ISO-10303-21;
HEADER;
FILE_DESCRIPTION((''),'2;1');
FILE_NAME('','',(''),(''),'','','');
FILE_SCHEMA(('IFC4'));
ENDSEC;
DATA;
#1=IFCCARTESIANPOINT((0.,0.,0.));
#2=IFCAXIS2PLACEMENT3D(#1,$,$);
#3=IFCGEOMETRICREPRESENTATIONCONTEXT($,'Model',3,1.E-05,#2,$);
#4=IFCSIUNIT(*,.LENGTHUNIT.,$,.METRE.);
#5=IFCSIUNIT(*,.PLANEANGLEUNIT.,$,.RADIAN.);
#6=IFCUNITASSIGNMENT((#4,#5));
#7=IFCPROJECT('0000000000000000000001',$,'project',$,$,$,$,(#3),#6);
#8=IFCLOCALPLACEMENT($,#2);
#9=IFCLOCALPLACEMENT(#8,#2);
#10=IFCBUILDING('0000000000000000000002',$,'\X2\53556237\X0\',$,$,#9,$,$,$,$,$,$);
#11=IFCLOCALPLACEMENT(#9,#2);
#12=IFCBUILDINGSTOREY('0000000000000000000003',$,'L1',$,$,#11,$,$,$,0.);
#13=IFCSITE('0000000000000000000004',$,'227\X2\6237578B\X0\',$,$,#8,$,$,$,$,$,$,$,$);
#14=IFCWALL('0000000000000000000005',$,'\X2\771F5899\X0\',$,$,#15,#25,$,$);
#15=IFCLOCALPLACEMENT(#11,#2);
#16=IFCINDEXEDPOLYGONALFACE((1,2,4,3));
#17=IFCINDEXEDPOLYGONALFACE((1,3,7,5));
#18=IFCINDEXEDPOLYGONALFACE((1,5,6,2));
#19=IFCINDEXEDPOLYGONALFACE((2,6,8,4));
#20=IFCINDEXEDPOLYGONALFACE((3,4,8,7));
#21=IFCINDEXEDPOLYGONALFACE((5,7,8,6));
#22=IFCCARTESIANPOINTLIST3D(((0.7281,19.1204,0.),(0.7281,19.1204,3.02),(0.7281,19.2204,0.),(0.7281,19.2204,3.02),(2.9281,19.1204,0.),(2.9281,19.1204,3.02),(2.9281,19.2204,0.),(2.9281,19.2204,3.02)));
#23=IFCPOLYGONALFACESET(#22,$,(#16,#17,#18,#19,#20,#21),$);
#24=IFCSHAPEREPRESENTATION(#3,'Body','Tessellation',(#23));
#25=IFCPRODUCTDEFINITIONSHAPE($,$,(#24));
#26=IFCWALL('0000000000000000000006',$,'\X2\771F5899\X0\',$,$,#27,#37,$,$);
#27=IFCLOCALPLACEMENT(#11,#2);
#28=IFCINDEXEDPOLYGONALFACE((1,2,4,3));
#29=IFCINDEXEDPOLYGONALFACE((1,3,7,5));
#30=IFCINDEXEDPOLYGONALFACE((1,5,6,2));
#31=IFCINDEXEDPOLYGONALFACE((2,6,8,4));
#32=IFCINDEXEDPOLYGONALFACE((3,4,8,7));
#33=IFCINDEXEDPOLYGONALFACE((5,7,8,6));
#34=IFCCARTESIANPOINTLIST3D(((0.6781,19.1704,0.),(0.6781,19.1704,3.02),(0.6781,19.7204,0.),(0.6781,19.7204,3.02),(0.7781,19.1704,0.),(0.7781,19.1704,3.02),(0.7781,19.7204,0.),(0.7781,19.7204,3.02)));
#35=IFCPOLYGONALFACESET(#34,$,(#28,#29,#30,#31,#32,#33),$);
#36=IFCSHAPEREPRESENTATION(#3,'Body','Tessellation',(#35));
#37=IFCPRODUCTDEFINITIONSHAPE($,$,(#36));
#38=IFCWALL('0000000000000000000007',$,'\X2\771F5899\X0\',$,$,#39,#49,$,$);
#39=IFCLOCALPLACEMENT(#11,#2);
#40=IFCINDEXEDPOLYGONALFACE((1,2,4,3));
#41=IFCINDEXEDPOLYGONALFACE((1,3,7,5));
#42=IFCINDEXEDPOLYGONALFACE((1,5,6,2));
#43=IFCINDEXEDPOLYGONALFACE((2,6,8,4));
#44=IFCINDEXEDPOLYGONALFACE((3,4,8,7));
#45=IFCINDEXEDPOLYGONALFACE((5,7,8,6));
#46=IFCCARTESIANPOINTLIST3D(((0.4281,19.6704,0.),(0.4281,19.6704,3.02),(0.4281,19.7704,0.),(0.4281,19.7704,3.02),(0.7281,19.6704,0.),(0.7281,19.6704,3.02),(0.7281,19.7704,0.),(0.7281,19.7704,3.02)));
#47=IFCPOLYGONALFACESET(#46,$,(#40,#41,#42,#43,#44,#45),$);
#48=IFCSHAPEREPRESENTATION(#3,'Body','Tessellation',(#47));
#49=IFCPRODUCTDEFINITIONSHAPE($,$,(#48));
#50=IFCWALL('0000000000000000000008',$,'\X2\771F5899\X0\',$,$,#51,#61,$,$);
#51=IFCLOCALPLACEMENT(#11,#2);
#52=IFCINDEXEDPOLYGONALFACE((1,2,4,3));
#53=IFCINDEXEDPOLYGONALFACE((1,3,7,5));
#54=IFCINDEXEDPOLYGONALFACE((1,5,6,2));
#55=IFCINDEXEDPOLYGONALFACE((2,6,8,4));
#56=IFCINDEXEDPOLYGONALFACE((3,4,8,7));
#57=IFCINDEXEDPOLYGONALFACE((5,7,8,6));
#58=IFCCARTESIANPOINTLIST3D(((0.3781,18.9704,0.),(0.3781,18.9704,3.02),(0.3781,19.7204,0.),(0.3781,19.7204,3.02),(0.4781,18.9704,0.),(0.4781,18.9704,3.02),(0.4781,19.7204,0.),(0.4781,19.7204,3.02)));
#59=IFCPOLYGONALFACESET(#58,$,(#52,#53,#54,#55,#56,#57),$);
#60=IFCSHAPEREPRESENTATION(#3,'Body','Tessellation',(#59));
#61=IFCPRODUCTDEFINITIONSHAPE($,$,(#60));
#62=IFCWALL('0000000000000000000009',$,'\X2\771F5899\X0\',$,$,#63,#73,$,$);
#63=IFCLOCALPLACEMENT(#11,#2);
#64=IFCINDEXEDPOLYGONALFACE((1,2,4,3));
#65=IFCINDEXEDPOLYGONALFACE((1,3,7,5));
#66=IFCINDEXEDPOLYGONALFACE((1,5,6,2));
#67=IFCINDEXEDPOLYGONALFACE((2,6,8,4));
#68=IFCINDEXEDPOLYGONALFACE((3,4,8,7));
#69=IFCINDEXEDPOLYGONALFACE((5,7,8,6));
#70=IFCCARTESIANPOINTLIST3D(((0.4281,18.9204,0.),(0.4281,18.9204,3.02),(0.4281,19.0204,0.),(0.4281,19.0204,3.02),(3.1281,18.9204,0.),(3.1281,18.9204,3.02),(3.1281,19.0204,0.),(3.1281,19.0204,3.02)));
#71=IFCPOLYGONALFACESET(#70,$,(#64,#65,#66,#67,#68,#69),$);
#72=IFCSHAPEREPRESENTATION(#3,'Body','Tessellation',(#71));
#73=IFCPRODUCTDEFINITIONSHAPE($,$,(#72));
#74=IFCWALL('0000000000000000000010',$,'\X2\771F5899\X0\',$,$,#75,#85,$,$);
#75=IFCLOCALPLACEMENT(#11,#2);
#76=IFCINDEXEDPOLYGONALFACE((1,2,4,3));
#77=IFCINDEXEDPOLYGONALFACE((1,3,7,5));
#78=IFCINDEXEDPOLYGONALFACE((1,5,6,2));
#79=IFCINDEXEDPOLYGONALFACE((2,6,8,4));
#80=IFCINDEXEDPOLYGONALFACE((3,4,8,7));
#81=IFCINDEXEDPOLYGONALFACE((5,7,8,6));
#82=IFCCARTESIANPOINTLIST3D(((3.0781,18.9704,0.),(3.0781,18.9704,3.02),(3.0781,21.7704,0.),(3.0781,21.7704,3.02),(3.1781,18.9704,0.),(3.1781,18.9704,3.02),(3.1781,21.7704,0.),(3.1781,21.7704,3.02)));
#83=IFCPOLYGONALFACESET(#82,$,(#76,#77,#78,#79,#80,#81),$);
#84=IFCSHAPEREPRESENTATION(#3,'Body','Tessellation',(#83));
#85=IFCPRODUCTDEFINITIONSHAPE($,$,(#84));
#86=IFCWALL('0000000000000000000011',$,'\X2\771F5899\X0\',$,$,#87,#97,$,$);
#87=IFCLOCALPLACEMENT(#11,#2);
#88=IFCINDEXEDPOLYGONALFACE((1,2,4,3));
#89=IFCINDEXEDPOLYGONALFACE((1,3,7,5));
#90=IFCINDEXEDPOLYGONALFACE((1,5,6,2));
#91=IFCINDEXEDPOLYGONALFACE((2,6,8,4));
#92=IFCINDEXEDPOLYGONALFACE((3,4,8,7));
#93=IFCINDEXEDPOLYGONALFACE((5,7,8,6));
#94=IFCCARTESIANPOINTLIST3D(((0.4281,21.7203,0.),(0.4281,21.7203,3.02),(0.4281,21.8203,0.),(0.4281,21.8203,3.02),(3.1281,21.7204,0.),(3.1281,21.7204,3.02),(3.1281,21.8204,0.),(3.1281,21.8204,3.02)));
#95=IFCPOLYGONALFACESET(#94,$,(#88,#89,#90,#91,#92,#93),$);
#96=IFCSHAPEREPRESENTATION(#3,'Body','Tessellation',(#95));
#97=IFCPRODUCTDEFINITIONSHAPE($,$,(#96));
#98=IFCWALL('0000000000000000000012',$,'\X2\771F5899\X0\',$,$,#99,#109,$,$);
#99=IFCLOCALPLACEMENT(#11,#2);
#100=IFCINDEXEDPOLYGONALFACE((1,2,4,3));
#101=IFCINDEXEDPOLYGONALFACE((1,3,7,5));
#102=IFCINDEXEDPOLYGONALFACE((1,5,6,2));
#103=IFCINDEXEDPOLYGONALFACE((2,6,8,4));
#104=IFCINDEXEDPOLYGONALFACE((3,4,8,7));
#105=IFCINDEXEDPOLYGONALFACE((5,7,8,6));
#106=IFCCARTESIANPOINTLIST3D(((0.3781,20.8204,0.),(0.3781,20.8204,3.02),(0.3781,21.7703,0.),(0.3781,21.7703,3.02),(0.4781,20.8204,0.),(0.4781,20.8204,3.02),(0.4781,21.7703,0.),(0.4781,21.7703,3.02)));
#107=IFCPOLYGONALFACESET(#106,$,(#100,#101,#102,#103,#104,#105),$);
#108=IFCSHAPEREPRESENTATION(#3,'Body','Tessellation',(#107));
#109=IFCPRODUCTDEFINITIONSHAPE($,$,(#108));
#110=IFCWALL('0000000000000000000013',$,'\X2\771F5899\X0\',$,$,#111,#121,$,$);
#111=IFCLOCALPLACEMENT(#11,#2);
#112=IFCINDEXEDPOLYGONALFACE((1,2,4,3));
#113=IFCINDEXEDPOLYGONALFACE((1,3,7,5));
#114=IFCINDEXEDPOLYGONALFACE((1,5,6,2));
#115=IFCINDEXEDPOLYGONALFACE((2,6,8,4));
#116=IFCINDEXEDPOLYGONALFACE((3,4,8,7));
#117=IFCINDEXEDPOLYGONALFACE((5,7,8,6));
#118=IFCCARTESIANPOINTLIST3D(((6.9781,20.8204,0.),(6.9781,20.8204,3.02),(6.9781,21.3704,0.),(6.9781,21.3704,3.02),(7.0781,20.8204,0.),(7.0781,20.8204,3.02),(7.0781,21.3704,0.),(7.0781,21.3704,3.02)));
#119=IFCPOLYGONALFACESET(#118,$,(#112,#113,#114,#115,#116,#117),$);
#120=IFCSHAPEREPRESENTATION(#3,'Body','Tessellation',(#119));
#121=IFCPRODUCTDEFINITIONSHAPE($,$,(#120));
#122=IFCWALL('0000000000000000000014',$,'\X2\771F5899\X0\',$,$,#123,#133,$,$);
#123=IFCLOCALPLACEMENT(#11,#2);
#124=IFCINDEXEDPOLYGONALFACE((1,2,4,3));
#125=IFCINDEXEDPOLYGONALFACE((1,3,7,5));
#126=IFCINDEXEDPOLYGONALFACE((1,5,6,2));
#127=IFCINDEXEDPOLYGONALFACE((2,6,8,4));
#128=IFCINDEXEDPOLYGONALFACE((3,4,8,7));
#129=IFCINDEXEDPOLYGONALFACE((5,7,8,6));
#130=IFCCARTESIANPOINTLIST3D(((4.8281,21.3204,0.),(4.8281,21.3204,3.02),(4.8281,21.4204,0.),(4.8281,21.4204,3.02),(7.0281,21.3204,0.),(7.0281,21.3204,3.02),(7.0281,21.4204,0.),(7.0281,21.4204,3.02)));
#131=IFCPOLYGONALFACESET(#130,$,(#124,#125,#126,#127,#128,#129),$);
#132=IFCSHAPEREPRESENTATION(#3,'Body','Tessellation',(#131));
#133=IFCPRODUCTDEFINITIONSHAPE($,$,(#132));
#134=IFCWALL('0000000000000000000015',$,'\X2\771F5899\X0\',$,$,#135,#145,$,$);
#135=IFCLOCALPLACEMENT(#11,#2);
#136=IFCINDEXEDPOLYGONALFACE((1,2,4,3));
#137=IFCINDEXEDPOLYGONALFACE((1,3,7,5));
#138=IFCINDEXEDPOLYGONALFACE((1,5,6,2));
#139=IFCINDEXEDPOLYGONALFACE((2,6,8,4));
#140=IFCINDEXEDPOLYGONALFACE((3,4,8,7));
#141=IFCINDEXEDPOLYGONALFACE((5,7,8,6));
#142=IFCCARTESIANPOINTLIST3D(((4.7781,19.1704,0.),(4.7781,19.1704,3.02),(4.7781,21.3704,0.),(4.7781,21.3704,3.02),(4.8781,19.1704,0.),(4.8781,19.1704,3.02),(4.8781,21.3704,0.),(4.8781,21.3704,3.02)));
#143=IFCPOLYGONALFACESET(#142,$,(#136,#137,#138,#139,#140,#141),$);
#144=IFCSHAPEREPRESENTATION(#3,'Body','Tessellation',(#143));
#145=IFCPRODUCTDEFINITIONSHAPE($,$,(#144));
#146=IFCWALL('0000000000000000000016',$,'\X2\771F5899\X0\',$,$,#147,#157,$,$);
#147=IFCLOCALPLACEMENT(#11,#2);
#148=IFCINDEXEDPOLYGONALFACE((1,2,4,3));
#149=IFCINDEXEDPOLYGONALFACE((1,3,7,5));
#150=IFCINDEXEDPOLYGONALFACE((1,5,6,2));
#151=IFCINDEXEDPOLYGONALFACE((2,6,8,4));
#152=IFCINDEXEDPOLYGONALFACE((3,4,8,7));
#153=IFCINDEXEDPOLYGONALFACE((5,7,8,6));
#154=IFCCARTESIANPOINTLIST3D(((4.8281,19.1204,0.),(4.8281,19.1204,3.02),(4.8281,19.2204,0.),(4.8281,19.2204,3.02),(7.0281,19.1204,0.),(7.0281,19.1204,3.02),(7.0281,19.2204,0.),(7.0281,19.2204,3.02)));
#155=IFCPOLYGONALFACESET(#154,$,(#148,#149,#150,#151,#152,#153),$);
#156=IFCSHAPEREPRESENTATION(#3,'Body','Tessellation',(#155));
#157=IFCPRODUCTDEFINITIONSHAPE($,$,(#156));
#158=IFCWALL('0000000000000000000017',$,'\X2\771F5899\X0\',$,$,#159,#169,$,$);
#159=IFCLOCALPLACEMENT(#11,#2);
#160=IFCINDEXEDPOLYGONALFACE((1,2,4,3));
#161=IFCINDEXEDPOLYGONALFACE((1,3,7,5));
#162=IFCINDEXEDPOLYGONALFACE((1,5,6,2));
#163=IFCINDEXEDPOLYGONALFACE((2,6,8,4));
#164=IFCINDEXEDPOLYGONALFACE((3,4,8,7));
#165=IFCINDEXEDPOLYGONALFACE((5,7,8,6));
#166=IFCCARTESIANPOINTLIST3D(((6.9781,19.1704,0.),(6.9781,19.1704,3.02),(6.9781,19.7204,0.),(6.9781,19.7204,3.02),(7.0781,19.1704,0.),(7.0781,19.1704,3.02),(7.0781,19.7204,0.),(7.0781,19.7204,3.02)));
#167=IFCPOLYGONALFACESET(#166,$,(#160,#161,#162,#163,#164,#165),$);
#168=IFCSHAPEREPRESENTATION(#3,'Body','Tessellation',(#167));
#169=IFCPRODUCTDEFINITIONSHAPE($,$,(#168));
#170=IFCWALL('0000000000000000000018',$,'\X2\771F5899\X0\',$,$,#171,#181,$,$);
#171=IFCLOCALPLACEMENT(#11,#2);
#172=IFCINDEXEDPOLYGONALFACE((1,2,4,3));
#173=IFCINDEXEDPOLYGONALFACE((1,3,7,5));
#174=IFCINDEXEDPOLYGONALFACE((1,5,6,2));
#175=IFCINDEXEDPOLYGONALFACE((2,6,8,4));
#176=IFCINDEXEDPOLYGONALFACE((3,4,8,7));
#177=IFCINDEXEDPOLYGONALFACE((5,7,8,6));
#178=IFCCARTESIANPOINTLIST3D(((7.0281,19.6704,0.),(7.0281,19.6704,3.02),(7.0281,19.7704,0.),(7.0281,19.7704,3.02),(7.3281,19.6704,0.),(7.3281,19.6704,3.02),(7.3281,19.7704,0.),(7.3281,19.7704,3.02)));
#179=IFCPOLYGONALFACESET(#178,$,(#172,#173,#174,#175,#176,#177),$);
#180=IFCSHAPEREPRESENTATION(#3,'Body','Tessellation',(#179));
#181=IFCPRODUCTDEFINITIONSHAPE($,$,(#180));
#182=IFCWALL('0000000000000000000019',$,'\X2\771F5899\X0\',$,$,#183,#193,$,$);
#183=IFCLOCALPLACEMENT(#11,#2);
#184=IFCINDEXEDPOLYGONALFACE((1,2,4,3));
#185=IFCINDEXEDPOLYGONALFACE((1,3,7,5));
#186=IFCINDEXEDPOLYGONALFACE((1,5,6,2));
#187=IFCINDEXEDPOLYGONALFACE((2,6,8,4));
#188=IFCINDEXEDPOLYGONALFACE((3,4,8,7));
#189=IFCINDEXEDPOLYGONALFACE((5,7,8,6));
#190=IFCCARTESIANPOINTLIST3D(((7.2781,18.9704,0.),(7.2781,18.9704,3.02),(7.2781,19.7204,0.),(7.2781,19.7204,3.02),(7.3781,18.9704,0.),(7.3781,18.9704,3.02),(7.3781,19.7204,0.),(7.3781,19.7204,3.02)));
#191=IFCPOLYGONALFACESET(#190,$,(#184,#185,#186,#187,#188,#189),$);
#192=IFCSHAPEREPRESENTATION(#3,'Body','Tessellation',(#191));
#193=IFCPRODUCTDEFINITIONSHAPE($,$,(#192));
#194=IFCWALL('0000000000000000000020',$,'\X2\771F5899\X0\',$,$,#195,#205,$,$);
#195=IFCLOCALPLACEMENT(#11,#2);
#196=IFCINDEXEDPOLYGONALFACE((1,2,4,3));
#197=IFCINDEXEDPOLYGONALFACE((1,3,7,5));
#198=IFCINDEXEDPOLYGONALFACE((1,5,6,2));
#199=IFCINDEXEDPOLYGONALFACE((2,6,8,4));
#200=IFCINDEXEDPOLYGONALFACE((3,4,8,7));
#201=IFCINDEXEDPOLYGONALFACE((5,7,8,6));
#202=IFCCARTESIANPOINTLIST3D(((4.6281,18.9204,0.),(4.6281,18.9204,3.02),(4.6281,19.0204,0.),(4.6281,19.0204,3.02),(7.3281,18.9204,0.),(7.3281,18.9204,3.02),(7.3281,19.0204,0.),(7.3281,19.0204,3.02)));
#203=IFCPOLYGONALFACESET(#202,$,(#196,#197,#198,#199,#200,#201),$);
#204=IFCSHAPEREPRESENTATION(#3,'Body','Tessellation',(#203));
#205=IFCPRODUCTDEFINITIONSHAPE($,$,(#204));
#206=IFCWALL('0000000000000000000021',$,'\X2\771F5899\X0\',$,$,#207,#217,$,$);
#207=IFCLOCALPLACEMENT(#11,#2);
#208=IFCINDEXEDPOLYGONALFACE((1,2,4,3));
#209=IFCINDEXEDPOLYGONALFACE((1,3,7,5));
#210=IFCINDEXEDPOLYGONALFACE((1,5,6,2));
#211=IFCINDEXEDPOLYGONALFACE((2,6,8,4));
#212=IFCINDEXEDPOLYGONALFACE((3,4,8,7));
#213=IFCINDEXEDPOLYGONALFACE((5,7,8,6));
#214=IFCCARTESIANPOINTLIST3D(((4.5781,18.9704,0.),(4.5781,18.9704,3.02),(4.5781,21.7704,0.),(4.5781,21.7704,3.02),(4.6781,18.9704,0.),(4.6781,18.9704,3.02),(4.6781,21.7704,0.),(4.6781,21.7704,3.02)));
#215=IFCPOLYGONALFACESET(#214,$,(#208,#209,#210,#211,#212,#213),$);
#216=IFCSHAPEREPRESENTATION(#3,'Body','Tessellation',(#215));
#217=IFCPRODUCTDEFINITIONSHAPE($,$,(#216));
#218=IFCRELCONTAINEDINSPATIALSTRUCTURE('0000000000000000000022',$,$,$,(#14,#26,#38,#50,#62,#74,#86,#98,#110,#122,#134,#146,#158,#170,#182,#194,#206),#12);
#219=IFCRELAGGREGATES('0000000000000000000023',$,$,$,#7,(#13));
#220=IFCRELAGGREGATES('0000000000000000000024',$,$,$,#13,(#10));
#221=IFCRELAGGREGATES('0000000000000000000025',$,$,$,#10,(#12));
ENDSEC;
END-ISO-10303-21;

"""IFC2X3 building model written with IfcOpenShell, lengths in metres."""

from ifc_helpers import new_model, si_unit, origin, place, context, project, spatial, polyline, outline, extrude, element, save


model = new_model("IFC2X3")

# Units and contexts
model_context = context("Model", 3, precision=1e-05, world=origin())
ifc_project = project(units=[si_unit("LENGTHUNIT", "METRE"), si_unit("PLANEANGLEUNIT", "RADIAN")], contexts=[model_context])

# Site, building, storey
site_placement = place(None, origin())
site = spatial("IfcSite", under=ifc_project, at=site_placement, Name="227户型")
building_placement = place(site_placement, origin())
building = spatial("IfcBuilding", under=site, at=building_placement, Name="单户")
storey_placement = place(building_placement, origin())
storey = spatial("IfcBuildingStorey", under=building, at=storey_placement, Name="L1", Elevation=0.0)

# Walls
wall_1_placement = place(storey_placement, origin())
element("IfcWall", 1, at=wall_1_placement, inside=storey, Name="真墙", context=model_context, shape_type="SweptSolid", body=[
    extrude(outline(polyline([(2.9281, 19.1204), (0.7281, 19.1204), (0.7281, 19.2204), (2.9281, 19.2204), (2.9281, 19.1204)])), origin(), (0.0, 0.0, 1.0), 3.02),
])
wall_2_placement = place(storey_placement, origin())
element("IfcWall", 2, at=wall_2_placement, inside=storey, Name="真墙", context=model_context, shape_type="SweptSolid", body=[
    extrude(outline(polyline([(0.6781, 19.1704), (0.6781, 19.7204), (0.7781, 19.7204), (0.7781, 19.1704), (0.6781, 19.1704)])), origin(), (0.0, 0.0, 1.0), 3.02),
])
wall_3_placement = place(storey_placement, origin())
element("IfcWall", 3, at=wall_3_placement, inside=storey, Name="真墙", context=model_context, shape_type="SweptSolid", body=[
    extrude(outline(polyline([(0.7281, 19.6704), (0.4281, 19.6704), (0.4281, 19.7704), (0.7281, 19.7704), (0.7281, 19.6704)])), origin(), (0.0, 0.0, 1.0), 3.02),
])
wall_4_placement = place(storey_placement, origin())
element("IfcWall", 4, at=wall_4_placement, inside=storey, Name="真墙", context=model_context, shape_type="SweptSolid", body=[
    extrude(outline(polyline([(0.4781, 19.7204), (0.4781, 18.9704), (0.3781, 18.9704), (0.3781, 19.7204), (0.4781, 19.7204)])), origin(), (0.0, 0.0, 1.0), 3.02),
])
wall_5_placement = place(storey_placement, origin())
element("IfcWall", 5, at=wall_5_placement, inside=storey, Name="真墙", context=model_context, shape_type="SweptSolid", body=[
    extrude(outline(polyline([(0.4281, 19.0204), (3.1281, 19.0204), (3.1281, 18.9204), (0.4281, 18.9204), (0.4281, 19.0204)])), origin(), (0.0, 0.0, 1.0), 3.02),
])
wall_6_placement = place(storey_placement, origin())
element("IfcWall", 6, at=wall_6_placement, inside=storey, Name="真墙", context=model_context, shape_type="SweptSolid", body=[
    extrude(outline(polyline([(3.0781, 18.9704), (3.0781, 21.7704), (3.1781, 21.7704), (3.1781, 18.9704), (3.0781, 18.9704)])), origin(), (0.0, 0.0, 1.0), 3.02),
])
wall_7_placement = place(storey_placement, origin())
element("IfcWall", 7, at=wall_7_placement, inside=storey, Name="真墙", context=model_context, shape_type="SweptSolid", body=[
    extrude(outline(polyline([(3.1281, 21.7204), (0.4281, 21.7203), (0.4281, 21.8203), (3.1281, 21.8204), (3.1281, 21.7204)])), origin(), (0.0, 0.0, 1.0), 3.02),
])
wall_8_placement = place(storey_placement, origin())
element("IfcWall", 8, at=wall_8_placement, inside=storey, Name="真墙", context=model_context, shape_type="SweptSolid", body=[
    extrude(outline(polyline([(0.4781, 21.7703), (0.4781, 20.8204), (0.3781, 20.8204), (0.3781, 21.7703), (0.4781, 21.7703)])), origin(), (0.0, 0.0, 1.0), 3.02),
])
wall_9_placement = place(storey_placement, origin())
element("IfcWall", 9, at=wall_9_placement, inside=storey, Name="真墙", context=model_context, shape_type="SweptSolid", body=[
    extrude(outline(polyline([(6.9781, 20.8204), (6.9781, 21.3704), (7.0781, 21.3704), (7.0781, 20.8204), (6.9781, 20.8204)])), origin(), (0.0, 0.0, 1.0), 3.02),
])
wall_10_placement = place(storey_placement, origin())
element("IfcWall", 10, at=wall_10_placement, inside=storey, Name="真墙", context=model_context, shape_type="SweptSolid", body=[
    extrude(outline(polyline([(7.0281, 21.3204), (4.8281, 21.3204), (4.8281, 21.4204), (7.0281, 21.4204), (7.0281, 21.3204)])), origin(), (0.0, 0.0, 1.0), 3.02),
])
wall_11_placement = place(storey_placement, origin())
element("IfcWall", 11, at=wall_11_placement, inside=storey, Name="真墙", context=model_context, shape_type="SweptSolid", body=[
    extrude(outline(polyline([(4.8781, 21.3704), (4.8781, 19.1704), (4.7781, 19.1704), (4.7781, 21.3704), (4.8781, 21.3704)])), origin(), (0.0, 0.0, 1.0), 3.02),
])
wall_12_placement = place(storey_placement, origin())
element("IfcWall", 12, at=wall_12_placement, inside=storey, Name="真墙", context=model_context, shape_type="SweptSolid", body=[
    extrude(outline(polyline([(4.8281, 19.2204), (7.0281, 19.2204), (7.0281, 19.1204), (4.8281, 19.1204), (4.8281, 19.2204)])), origin(), (0.0, 0.0, 1.0), 3.02),
])
wall_13_placement = place(storey_placement, origin())
element("IfcWall", 13, at=wall_13_placement, inside=storey, Name="真墙", context=model_context, shape_type="SweptSolid", body=[
    extrude(outline(polyline([(6.9781, 19.1704), (6.9781, 19.7204), (7.0781, 19.7204), (7.0781, 19.1704), (6.9781, 19.1704)])), origin(), (0.0, 0.0, 1.0), 3.02),
])
wall_14_placement = place(storey_placement, origin())
element("IfcWall", 14, at=wall_14_placement, inside=storey, Name="真墙", context=model_context, shape_type="SweptSolid", body=[
    extrude(outline(polyline([(7.0281, 19.7704), (7.3281, 19.7704), (7.3281, 19.6704), (7.0281, 19.6704), (7.0281, 19.7704)])), origin(), (0.0, 0.0, 1.0), 3.02),
])
wall_15_placement = place(storey_placement, origin())
element("IfcWall", 15, at=wall_15_placement, inside=storey, Name="真墙", context=model_context, shape_type="SweptSolid", body=[
    extrude(outline(polyline([(7.3781, 19.7204), (7.3781, 18.9704), (7.2781, 18.9704), (7.2781, 19.7204), (7.3781, 19.7204)])), origin(), (0.0, 0.0, 1.0), 3.02),
])
wall_16_placement = place(storey_placement, origin())
element("IfcWall", 16, at=wall_16_placement, inside=storey, Name="真墙", context=model_context, shape_type="SweptSolid", body=[
    extrude(outline(polyline([(7.3281, 18.9204), (4.6281, 18.9204), (4.6281, 19.0204), (7.3281, 19.0204), (7.3281, 18.9204)])), origin(), (0.0, 0.0, 1.0), 3.02),
])
wall_17_placement = place(storey_placement, origin())
element("IfcWall", 17, at=wall_17_placement, inside=storey, Name="真墙", context=model_context, shape_type="SweptSolid", body=[
    extrude(outline(polyline([(4.5781, 18.9704), (4.5781, 21.7704), (4.6781, 21.7704), (4.6781, 18.9704), (4.5781, 18.9704)])), origin(), (0.0, 0.0, 1.0), 3.02),
])

save(model, "model.ifc")
